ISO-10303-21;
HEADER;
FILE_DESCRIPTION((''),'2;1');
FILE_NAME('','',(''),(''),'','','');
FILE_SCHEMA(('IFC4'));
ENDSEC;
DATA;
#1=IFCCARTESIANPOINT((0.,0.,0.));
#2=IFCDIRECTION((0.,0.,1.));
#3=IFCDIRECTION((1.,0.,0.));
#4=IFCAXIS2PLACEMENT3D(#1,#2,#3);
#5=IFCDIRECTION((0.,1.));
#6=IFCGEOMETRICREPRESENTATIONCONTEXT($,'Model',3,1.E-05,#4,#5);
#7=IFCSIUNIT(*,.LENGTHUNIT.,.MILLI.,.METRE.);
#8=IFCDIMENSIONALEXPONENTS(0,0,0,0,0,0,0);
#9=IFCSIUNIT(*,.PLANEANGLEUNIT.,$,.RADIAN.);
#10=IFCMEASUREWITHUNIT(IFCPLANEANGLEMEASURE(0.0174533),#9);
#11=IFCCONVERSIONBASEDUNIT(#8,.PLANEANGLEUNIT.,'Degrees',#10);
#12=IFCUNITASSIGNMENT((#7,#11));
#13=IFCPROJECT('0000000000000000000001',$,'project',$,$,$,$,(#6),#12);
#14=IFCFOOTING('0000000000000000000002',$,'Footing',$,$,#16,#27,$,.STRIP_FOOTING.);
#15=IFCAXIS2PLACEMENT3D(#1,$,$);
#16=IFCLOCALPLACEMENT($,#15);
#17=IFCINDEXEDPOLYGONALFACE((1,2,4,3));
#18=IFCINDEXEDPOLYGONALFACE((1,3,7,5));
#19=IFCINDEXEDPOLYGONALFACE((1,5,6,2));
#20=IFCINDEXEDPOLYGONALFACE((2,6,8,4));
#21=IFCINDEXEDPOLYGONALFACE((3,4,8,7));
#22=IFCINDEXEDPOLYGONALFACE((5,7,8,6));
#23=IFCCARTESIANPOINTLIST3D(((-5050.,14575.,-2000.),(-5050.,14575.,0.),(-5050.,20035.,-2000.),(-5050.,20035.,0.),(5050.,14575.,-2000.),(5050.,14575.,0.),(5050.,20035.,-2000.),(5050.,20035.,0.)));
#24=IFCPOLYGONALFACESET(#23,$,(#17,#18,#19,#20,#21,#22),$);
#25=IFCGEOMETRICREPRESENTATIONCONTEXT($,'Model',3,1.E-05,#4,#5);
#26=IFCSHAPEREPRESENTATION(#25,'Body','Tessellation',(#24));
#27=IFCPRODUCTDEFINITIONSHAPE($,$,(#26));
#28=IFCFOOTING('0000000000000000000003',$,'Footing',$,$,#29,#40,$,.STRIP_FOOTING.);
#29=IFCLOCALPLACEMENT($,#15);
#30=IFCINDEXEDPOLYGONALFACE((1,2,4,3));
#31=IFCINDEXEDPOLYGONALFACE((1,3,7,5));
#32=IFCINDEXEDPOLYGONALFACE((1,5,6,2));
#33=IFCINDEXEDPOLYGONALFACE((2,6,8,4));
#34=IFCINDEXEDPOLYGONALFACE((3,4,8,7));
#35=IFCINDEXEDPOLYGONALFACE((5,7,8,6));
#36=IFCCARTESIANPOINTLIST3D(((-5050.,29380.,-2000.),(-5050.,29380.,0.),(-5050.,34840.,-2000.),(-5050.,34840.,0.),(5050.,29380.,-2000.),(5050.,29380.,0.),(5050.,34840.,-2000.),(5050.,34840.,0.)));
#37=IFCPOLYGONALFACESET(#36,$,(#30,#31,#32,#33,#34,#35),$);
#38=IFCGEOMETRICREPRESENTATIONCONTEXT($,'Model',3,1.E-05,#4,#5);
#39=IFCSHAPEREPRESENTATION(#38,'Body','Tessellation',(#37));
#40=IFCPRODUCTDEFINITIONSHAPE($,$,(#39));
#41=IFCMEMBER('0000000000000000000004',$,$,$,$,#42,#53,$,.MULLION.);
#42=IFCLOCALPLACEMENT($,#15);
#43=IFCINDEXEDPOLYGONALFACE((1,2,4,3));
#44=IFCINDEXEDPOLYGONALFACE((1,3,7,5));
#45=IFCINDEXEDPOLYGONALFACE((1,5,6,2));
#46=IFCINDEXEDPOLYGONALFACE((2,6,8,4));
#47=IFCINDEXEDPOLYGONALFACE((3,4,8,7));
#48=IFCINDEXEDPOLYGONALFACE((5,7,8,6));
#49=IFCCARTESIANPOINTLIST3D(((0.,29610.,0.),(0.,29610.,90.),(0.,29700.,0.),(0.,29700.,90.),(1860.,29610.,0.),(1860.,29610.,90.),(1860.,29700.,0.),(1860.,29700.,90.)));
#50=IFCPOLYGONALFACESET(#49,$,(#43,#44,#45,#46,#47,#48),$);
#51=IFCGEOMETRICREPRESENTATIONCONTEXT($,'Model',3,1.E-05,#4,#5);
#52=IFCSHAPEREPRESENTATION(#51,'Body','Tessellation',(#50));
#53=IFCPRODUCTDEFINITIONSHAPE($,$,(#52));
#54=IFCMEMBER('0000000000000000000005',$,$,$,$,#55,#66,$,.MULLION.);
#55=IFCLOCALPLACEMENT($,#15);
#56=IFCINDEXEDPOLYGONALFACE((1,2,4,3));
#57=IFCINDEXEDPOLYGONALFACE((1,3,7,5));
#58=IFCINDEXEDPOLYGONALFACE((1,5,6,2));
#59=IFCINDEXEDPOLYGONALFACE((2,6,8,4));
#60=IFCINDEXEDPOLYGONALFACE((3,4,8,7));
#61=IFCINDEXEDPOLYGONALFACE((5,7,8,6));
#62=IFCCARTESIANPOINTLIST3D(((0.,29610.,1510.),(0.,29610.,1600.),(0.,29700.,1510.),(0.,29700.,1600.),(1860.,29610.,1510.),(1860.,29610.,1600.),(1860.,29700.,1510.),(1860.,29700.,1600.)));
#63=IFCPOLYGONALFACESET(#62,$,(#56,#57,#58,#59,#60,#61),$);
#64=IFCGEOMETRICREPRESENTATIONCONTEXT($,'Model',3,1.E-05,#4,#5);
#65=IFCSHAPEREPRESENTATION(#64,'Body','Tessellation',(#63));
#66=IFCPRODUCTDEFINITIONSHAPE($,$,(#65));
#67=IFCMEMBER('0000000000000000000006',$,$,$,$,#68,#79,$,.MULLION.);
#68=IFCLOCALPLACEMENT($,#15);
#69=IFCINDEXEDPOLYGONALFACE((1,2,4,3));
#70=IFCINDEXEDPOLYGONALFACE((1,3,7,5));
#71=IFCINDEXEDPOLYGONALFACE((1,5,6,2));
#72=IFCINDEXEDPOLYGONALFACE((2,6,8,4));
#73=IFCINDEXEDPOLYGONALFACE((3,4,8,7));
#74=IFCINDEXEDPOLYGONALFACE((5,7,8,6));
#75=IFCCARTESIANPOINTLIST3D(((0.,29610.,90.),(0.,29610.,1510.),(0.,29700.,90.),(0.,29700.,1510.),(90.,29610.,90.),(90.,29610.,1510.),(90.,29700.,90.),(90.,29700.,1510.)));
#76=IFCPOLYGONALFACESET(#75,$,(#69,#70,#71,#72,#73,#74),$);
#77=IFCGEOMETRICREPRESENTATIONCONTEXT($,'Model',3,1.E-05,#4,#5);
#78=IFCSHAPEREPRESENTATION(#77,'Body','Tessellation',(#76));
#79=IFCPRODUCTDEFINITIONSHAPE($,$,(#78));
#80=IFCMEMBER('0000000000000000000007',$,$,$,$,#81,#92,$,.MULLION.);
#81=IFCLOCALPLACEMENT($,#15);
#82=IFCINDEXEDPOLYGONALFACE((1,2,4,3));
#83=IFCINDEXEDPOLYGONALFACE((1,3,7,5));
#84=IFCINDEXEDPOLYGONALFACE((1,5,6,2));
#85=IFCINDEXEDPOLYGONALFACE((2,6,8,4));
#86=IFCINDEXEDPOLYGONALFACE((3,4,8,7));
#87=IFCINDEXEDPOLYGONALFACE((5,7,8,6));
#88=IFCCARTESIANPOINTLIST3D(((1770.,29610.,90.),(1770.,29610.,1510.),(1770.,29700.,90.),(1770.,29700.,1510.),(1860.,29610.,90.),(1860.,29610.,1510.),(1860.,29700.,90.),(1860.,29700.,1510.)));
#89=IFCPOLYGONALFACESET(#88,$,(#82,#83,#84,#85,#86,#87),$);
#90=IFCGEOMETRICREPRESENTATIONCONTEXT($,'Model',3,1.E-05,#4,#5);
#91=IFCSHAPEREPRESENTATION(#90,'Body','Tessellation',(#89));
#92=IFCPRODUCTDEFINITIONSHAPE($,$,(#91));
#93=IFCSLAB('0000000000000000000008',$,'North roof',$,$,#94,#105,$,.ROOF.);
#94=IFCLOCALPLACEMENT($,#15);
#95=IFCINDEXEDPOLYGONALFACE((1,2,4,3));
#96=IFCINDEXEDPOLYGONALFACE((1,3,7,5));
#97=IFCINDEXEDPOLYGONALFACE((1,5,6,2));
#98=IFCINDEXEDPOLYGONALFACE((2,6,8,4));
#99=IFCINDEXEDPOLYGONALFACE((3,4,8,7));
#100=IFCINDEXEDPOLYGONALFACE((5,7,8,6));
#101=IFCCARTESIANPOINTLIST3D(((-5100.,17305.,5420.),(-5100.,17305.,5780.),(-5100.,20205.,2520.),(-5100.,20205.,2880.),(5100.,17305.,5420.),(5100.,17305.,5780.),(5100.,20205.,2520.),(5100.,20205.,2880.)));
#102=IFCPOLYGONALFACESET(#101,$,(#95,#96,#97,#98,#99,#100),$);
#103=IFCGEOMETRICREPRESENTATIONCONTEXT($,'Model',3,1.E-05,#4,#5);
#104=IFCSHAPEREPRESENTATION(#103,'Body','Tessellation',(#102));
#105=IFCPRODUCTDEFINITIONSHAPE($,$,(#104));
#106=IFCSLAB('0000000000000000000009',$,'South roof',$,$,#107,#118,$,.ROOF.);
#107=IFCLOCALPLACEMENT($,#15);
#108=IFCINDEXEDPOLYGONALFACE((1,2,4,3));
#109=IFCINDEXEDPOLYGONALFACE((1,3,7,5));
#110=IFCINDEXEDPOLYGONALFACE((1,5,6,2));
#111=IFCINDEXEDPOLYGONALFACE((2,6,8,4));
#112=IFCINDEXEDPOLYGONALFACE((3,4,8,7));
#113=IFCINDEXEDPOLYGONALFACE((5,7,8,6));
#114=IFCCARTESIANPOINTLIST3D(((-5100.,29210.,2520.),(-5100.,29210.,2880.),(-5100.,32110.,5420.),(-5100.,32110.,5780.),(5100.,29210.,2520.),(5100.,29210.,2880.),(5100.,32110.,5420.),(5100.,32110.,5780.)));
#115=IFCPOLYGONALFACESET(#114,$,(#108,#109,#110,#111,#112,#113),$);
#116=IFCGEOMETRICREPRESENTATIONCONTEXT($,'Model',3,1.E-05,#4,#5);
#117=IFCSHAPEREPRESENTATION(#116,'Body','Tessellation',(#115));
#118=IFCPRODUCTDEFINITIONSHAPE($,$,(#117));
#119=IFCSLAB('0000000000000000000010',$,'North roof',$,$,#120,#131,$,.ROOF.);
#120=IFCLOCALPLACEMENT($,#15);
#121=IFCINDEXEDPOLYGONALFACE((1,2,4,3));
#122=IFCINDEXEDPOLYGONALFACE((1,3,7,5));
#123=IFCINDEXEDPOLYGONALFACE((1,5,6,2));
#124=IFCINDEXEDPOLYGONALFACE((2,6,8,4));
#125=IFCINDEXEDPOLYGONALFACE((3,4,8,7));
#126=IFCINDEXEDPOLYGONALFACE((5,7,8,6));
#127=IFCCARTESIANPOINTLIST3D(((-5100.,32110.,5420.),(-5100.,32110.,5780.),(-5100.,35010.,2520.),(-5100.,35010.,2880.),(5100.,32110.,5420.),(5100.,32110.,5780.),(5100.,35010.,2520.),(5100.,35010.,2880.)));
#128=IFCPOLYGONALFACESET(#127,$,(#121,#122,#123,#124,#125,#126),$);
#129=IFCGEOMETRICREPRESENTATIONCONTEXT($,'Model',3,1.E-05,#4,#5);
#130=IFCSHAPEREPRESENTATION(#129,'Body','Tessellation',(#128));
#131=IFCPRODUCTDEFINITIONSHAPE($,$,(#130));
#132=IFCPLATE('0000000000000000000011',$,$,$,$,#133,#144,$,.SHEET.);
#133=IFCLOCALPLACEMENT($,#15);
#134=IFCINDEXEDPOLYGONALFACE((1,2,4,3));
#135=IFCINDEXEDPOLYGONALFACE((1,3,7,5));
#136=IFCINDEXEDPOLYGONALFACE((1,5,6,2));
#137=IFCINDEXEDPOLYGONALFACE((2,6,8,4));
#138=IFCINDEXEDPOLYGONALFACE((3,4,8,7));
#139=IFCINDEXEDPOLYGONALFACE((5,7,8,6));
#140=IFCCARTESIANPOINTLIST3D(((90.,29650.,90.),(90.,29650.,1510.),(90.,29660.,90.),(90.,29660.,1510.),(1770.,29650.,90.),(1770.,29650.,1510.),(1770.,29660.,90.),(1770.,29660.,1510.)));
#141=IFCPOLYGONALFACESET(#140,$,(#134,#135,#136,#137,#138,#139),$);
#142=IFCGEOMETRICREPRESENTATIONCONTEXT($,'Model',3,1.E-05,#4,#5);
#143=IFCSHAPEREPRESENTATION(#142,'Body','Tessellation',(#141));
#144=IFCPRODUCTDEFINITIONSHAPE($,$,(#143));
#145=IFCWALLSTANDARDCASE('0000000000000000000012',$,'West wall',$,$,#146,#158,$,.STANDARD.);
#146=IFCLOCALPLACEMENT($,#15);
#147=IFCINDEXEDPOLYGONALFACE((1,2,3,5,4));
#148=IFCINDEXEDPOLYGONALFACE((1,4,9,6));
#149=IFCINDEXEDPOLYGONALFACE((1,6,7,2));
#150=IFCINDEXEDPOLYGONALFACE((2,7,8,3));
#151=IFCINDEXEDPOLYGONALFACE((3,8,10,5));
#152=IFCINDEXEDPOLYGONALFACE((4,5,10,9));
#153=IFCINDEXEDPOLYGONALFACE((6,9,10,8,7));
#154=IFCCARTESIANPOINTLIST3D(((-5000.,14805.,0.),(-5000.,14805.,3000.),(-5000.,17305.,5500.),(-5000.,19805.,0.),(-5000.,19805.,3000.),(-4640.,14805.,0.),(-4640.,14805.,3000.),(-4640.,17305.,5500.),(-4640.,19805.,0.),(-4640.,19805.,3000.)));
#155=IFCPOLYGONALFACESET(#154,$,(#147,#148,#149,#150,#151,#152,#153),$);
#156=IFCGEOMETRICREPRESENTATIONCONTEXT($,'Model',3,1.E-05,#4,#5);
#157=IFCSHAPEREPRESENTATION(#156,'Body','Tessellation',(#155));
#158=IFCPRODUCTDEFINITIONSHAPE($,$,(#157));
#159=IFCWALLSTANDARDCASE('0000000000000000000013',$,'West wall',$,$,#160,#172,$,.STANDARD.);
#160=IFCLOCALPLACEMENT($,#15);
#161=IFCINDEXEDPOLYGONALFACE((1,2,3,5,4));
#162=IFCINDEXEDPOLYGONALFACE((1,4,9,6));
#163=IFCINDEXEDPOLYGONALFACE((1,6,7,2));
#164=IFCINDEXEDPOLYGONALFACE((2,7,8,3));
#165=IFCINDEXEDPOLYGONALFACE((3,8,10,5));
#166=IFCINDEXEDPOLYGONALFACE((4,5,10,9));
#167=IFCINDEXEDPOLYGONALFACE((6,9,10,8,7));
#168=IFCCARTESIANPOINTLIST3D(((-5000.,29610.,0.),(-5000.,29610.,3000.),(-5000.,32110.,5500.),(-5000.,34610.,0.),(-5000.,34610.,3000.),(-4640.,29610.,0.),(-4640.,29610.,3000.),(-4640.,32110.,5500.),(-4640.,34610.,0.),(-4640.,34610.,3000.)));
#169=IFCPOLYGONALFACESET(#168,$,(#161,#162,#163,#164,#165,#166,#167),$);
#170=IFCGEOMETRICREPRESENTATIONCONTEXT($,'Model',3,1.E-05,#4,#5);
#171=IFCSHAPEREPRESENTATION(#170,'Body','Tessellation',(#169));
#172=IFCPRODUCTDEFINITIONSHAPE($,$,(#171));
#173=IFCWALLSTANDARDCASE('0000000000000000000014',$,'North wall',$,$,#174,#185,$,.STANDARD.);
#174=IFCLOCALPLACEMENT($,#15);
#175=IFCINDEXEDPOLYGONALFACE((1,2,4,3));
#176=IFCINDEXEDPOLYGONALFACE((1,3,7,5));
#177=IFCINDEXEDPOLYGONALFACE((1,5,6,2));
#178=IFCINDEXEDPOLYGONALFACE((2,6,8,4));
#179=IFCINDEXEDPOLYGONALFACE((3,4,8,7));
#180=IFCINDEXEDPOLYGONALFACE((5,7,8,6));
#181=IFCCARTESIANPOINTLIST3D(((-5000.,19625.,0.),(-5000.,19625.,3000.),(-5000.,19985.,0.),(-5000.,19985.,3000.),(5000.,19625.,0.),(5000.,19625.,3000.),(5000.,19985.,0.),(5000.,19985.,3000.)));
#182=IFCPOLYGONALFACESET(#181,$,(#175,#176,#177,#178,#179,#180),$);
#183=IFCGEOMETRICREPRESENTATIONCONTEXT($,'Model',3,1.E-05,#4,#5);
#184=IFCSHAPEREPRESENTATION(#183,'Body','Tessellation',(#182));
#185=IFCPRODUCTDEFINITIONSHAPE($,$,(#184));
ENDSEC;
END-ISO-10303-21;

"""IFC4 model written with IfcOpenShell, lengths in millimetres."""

from ifc_helpers import new_model, entity, si_unit, converted_unit, direction, frame, origin_with_axes, place, context, project, polyline, outline, extrude, clip, halfspace, source, transform, mapped, element, save


model = new_model("IFC4")

# Units and contexts
model_context_1 = context("Model", 3, precision=1e-05, world=origin_with_axes(), true_north=direction((0.0, 1.0)))
model_context_2 = context("Model", 3, precision=1e-05, world=origin_with_axes(), true_north=direction((0.0, 1.0)))
model_context_3 = context("Model", 3, precision=1e-05, world=origin_with_axes(), true_north=direction((0.0, 1.0)))
model_context_4 = context("Model", 3, precision=1e-05, world=origin_with_axes(), true_north=direction((0.0, 1.0)))
model_context_5 = context("Model", 3, precision=1e-05, world=origin_with_axes(), true_north=direction((0.0, 1.0)))
model_context_6 = context("Model", 3, precision=1e-05, world=origin_with_axes(), true_north=direction((0.0, 1.0)))
model_context_7 = context("Model", 3, precision=1e-05, world=origin_with_axes(), true_north=direction((0.0, 1.0)))
model_context_8 = context("Model", 3, precision=1e-05, world=origin_with_axes(), true_north=direction((0.0, 1.0)))
model_context_9 = context("Model", 3, precision=1e-05, world=origin_with_axes(), true_north=direction((0.0, 1.0)))
model_context_10 = context("Model", 3, precision=1e-05, world=origin_with_axes(), true_north=direction((0.0, 1.0)))
model_context_11 = context("Model", 3, precision=1e-05, world=origin_with_axes(), true_north=direction((0.0, 1.0)))
model_context_12 = context("Model", 3, precision=1e-05, world=origin_with_axes(), true_north=direction((0.0, 1.0)))
model_context_13 = context("Model", 3, precision=1e-05, world=origin_with_axes(), true_north=direction((0.0, 1.0)))
model_context_14 = context("Model", 3, precision=1e-05, world=origin_with_axes(), true_north=direction((0.0, 1.0)))
ifc_project = project(units=[si_unit("LENGTHUNIT", "METRE", prefix="MILLI"), converted_unit("PLANEANGLEUNIT", "Degrees", entity("IfcPlaneAngleMeasure", 0.0174533), si_unit("PLANEANGLEUNIT", "RADIAN"), dimensions=[0, 0, 0, 0, 0, 0, 0])], contexts=[model_context_1])

# Footings
placement_1 = place(None, frame((0.0, 14805.0, 0.0)))
footing_1_placement = place(placement_1, frame((0.0, 2500.0, -2000.0), z_axis=(0.0, 0.0, 1.0), x_axis=(1.0, 0.0, 0.0)))
element("IfcFooting", 1, at=footing_1_placement, Name="Footing", PredefinedType="STRIP_FOOTING", context=model_context_2, shape_type="SweptSolid", body=[
    extrude(outline(polyline([(-5050.0, -2730.0), (5050.0, -2730.0), (5050.0, 2730.0), (-5050.0, 2730.0), (-5050.0, -2730.0), (-5050.0, -2730.0)])), origin_with_axes(), (0.0, 0.0, 1.0), 2000.0),
])
placement_2 = place(None, frame((0.0, 29610.0, 0.0)))
footing_2_placement = place(placement_2, frame((0.0, 2500.0, -2000.0), z_axis=(0.0, 0.0, 1.0), x_axis=(1.0, 0.0, 0.0)))
element("IfcFooting", 2, at=footing_2_placement, Name="Footing", PredefinedType="STRIP_FOOTING", context=model_context_6, shape_type="SweptSolid", body=[
    extrude(outline(polyline([(-5050.0, -2730.0), (5050.0, -2730.0), (5050.0, 2730.0), (-5050.0, 2730.0), (-5050.0, -2730.0), (-5050.0, -2730.0)])), origin_with_axes(), (0.0, 0.0, 1.0), 2000.0),
])

# Members
shared_shape_1 = source(origin_with_axes(), model_context_7, "Body", "SweptSolid", [
    extrude(outline(polyline([(-930.0, -45.0), (930.0, -45.0), (930.0, 45.0), (-930.0, 45.0), (-930.0, -45.0), (-930.0, -45.0)])), origin_with_axes(), (0.0, 0.0, 1.0), 90.0),
])
member_1_placement = place(placement_2, frame((930.0, 45.0, 0.0), z_axis=(0.0, 0.0, 1.0), x_axis=(1.0, 0.0, 0.0)))
element("IfcMember", 3, at=member_1_placement, PredefinedType="MULLION", context=model_context_7, shape_type="MappedRepresentation", body=[
    mapped(shared_shape_1, transform((0.0, 0.0, 0.0))),
])
shared_shape_2 = source(origin_with_axes(), model_context_8, "Body", "SweptSolid", [
    extrude(outline(polyline([(-930.0, -45.0), (930.0, -45.0), (930.0, 45.0), (-930.0, 45.0), (-930.0, -45.0), (-930.0, -45.0)])), origin_with_axes(), (0.0, 0.0, 1.0), 90.0),
])
member_2_placement = place(placement_2, frame((930.0, 45.0, 1510.0), z_axis=(0.0, 0.0, 1.0), x_axis=(1.0, 0.0, 0.0)))
element("IfcMember", 4, at=member_2_placement, PredefinedType="MULLION", context=model_context_8, shape_type="MappedRepresentation", body=[
    mapped(shared_shape_2, transform((0.0, 0.0, 0.0))),
])
shared_shape_3 = source(origin_with_axes(), model_context_9, "Body", "SweptSolid", [
    extrude(outline(polyline([(-45.0, -45.0), (45.0, -45.0), (45.0, 45.0), (-45.0, 45.0), (-45.0, -45.0), (-45.0, -45.0)])), origin_with_axes(), (0.0, 0.0, 1.0), 1420.0),
])
member_3_placement = place(placement_2, frame((45.0, 45.0, 90.0), z_axis=(0.0, 0.0, 1.0), x_axis=(1.0, 0.0, 0.0)))
element("IfcMember", 5, at=member_3_placement, PredefinedType="MULLION", context=model_context_9, shape_type="MappedRepresentation", body=[
    mapped(shared_shape_3, transform((0.0, 0.0, 0.0))),
])
shared_shape_4 = source(origin_with_axes(), model_context_10, "Body", "SweptSolid", [
    extrude(outline(polyline([(-45.0, -45.0), (45.0, -45.0), (45.0, 45.0), (-45.0, 45.0), (-45.0, -45.0), (-45.0, -45.0)])), origin_with_axes(), (0.0, 0.0, 1.0), 1420.0),
])
member_4_placement = place(placement_2, frame((1815.0, 45.0, 90.0), z_axis=(0.0, 0.0, 1.0), x_axis=(1.0, 0.0, 0.0)))
element("IfcMember", 6, at=member_4_placement, PredefinedType="MULLION", context=model_context_10, shape_type="MappedRepresentation", body=[
    mapped(shared_shape_4, transform((0.0, 0.0, 0.0))),
])

# Slabs
shared_shape_5 = source(origin_with_axes(), model_context_3, "Body", "SweptSolid", [
    extrude(outline(polyline([(-5100.0, -180.0), (5100.0, -180.0), (5100.0, 180.0), (-5100.0, 180.0), (-5100.0, -180.0), (-5100.0, -180.0)])), frame((0.0, 0.0, 0.0), z_axis=(0.0, 1.0, 0.0), x_axis=(1.0, 0.0, 0.0)), (0.0, -0.707107, 0.707107), 4101.2),
])
slab_1_placement = place(placement_1, frame((0.0, 5400.0, 2700.0), z_axis=(0.0, 0.0, 1.0), x_axis=(-1.0, 0.0, 0.0)))
element("IfcSlab", 7, at=slab_1_placement, Name="North roof", PredefinedType="ROOF", context=model_context_3, shape_type="MappedRepresentation", body=[
    mapped(shared_shape_5, transform((0.0, 0.0, 0.0))),
])
shared_shape_6 = source(origin_with_axes(), model_context_12, "Body", "SweptSolid", [
    extrude(outline(polyline([(-5100.0, -180.0), (5100.0, -180.0), (5100.0, 180.0), (-5100.0, 180.0), (-5100.0, -180.0), (-5100.0, -180.0)])), frame((0.0, 0.0, 0.0), z_axis=(0.0, 1.0, 0.0), x_axis=(1.0, 0.0, 0.0)), (0.0, -0.707107, 0.707107), 4101.2),
])
slab_2_placement = place(placement_2, frame((0.0, -400.0, 2700.0), z_axis=(0.0, 0.0, 1.0), x_axis=(1.0, 0.0, 0.0)))
element("IfcSlab", 8, at=slab_2_placement, Name="South roof", PredefinedType="ROOF", context=model_context_12, shape_type="MappedRepresentation", body=[
    mapped(shared_shape_6, transform((0.0, 0.0, 0.0))),
])
shared_shape_7 = source(origin_with_axes(), model_context_13, "Body", "SweptSolid", [
    extrude(outline(polyline([(-5100.0, -180.0), (5100.0, -180.0), (5100.0, 180.0), (-5100.0, 180.0), (-5100.0, -180.0), (-5100.0, -180.0)])), frame((0.0, 0.0, 0.0), z_axis=(0.0, 1.0, 0.0), x_axis=(1.0, 0.0, 0.0)), (0.0, -0.707107, 0.707107), 4101.2),
])
slab_3_placement = place(placement_2, frame((0.0, 5400.0, 2700.0), z_axis=(0.0, 0.0, 1.0), x_axis=(-1.0, 0.0, 0.0)))
element("IfcSlab", 9, at=slab_3_placement, Name="North roof", PredefinedType="ROOF", context=model_context_13, shape_type="MappedRepresentation", body=[
    mapped(shared_shape_7, transform((0.0, 0.0, 0.0))),
])

# Plate
plate_1_placement = place(placement_2, frame((930.0, 45.0, 90.0), z_axis=(0.0, 0.0, 1.0), x_axis=(1.0, 0.0, 0.0)))
element("IfcPlate", 10, at=plate_1_placement, PredefinedType="SHEET", context=model_context_11, shape_type="SweptSolid", body=[
    extrude(outline(polyline([(-840.0, -5.0), (840.0, -5.0), (840.0, 5.0), (-840.0, 5.0), (-840.0, -5.0), (-840.0, -5.0)])), origin_with_axes(), (0.0, 0.0, 1.0), 1420.0),
])

# Walls
shared_shape_8 = source(origin_with_axes(), model_context_5, "Body", "Clipping", [
    clip(clip(extrude(outline(polyline([(-2500.0, -180.0), (2500.0, -180.0), (2500.0, 180.0), (-2500.0, 180.0), (-2500.0, -180.0), (-2500.0, -180.0)])), origin_with_axes(), (0.0, 0.0, 1.0), 6000.0), halfspace(frame((-2500.0, 0.0, 3000.0), z_axis=(-1.0, 0.0, 1.0), x_axis=(1.0, 0.0, 0.0)), False)), halfspace(frame((2500.0, 0.0, 3000.0), z_axis=(1.0, 0.0, 1.0), x_axis=(1.0, 0.0, 0.0)), False)),
])
wall_1_placement = place(placement_1, frame((-4820.0, 2500.0, 0.0), z_axis=(0.0, 0.0, 1.0), x_axis=(0.0, -1.0, 0.0)))
element("IfcWallStandardCase", 11, at=wall_1_placement, Name="West wall", PredefinedType="STANDARD", context=model_context_5, shape_type="MappedRepresentation", body=[
    mapped(shared_shape_8, transform((0.0, 0.0, 0.0))),
])
shared_shape_9 = source(origin_with_axes(), model_context_14, "Body", "Clipping", [
    clip(clip(extrude(outline(polyline([(-2500.0, -180.0), (2500.0, -180.0), (2500.0, 180.0), (-2500.0, 180.0), (-2500.0, -180.0), (-2500.0, -180.0)])), origin_with_axes(), (0.0, 0.0, 1.0), 6000.0), halfspace(frame((-2500.0, 0.0, 3000.0), z_axis=(-1.0, 0.0, 1.0), x_axis=(1.0, 0.0, 0.0)), False)), halfspace(frame((2500.0, 0.0, 3000.0), z_axis=(1.0, 0.0, 1.0), x_axis=(1.0, 0.0, 0.0)), False)),
])
wall_2_placement = place(placement_2, frame((-4820.0, 2500.0, 0.0), z_axis=(0.0, 0.0, 1.0), x_axis=(0.0, -1.0, 0.0)))
element("IfcWallStandardCase", 12, at=wall_2_placement, Name="West wall", PredefinedType="STANDARD", context=model_context_14, shape_type="MappedRepresentation", body=[
    mapped(shared_shape_9, transform((0.0, 0.0, 0.0))),
])
wall_3_placement = place(placement_1, frame((0.0, 5000.0, 0.0), z_axis=(0.0, 0.0, 1.0), x_axis=(1.0, 0.0, 0.0)))
element("IfcWallStandardCase", 13, at=wall_3_placement, Name="North wall", PredefinedType="STANDARD", context=model_context_4, shape_type="SweptSolid", body=[
    extrude(outline(polyline([(-5000.0, -180.0), (5000.0, -180.0), (5000.0, 180.0), (-5000.0, 180.0), (-5000.0, -180.0), (-5000.0, -180.0)])), origin_with_axes(), (0.0, 0.0, 1.0), 3000.0),
])

save(model, "model.ifc")
